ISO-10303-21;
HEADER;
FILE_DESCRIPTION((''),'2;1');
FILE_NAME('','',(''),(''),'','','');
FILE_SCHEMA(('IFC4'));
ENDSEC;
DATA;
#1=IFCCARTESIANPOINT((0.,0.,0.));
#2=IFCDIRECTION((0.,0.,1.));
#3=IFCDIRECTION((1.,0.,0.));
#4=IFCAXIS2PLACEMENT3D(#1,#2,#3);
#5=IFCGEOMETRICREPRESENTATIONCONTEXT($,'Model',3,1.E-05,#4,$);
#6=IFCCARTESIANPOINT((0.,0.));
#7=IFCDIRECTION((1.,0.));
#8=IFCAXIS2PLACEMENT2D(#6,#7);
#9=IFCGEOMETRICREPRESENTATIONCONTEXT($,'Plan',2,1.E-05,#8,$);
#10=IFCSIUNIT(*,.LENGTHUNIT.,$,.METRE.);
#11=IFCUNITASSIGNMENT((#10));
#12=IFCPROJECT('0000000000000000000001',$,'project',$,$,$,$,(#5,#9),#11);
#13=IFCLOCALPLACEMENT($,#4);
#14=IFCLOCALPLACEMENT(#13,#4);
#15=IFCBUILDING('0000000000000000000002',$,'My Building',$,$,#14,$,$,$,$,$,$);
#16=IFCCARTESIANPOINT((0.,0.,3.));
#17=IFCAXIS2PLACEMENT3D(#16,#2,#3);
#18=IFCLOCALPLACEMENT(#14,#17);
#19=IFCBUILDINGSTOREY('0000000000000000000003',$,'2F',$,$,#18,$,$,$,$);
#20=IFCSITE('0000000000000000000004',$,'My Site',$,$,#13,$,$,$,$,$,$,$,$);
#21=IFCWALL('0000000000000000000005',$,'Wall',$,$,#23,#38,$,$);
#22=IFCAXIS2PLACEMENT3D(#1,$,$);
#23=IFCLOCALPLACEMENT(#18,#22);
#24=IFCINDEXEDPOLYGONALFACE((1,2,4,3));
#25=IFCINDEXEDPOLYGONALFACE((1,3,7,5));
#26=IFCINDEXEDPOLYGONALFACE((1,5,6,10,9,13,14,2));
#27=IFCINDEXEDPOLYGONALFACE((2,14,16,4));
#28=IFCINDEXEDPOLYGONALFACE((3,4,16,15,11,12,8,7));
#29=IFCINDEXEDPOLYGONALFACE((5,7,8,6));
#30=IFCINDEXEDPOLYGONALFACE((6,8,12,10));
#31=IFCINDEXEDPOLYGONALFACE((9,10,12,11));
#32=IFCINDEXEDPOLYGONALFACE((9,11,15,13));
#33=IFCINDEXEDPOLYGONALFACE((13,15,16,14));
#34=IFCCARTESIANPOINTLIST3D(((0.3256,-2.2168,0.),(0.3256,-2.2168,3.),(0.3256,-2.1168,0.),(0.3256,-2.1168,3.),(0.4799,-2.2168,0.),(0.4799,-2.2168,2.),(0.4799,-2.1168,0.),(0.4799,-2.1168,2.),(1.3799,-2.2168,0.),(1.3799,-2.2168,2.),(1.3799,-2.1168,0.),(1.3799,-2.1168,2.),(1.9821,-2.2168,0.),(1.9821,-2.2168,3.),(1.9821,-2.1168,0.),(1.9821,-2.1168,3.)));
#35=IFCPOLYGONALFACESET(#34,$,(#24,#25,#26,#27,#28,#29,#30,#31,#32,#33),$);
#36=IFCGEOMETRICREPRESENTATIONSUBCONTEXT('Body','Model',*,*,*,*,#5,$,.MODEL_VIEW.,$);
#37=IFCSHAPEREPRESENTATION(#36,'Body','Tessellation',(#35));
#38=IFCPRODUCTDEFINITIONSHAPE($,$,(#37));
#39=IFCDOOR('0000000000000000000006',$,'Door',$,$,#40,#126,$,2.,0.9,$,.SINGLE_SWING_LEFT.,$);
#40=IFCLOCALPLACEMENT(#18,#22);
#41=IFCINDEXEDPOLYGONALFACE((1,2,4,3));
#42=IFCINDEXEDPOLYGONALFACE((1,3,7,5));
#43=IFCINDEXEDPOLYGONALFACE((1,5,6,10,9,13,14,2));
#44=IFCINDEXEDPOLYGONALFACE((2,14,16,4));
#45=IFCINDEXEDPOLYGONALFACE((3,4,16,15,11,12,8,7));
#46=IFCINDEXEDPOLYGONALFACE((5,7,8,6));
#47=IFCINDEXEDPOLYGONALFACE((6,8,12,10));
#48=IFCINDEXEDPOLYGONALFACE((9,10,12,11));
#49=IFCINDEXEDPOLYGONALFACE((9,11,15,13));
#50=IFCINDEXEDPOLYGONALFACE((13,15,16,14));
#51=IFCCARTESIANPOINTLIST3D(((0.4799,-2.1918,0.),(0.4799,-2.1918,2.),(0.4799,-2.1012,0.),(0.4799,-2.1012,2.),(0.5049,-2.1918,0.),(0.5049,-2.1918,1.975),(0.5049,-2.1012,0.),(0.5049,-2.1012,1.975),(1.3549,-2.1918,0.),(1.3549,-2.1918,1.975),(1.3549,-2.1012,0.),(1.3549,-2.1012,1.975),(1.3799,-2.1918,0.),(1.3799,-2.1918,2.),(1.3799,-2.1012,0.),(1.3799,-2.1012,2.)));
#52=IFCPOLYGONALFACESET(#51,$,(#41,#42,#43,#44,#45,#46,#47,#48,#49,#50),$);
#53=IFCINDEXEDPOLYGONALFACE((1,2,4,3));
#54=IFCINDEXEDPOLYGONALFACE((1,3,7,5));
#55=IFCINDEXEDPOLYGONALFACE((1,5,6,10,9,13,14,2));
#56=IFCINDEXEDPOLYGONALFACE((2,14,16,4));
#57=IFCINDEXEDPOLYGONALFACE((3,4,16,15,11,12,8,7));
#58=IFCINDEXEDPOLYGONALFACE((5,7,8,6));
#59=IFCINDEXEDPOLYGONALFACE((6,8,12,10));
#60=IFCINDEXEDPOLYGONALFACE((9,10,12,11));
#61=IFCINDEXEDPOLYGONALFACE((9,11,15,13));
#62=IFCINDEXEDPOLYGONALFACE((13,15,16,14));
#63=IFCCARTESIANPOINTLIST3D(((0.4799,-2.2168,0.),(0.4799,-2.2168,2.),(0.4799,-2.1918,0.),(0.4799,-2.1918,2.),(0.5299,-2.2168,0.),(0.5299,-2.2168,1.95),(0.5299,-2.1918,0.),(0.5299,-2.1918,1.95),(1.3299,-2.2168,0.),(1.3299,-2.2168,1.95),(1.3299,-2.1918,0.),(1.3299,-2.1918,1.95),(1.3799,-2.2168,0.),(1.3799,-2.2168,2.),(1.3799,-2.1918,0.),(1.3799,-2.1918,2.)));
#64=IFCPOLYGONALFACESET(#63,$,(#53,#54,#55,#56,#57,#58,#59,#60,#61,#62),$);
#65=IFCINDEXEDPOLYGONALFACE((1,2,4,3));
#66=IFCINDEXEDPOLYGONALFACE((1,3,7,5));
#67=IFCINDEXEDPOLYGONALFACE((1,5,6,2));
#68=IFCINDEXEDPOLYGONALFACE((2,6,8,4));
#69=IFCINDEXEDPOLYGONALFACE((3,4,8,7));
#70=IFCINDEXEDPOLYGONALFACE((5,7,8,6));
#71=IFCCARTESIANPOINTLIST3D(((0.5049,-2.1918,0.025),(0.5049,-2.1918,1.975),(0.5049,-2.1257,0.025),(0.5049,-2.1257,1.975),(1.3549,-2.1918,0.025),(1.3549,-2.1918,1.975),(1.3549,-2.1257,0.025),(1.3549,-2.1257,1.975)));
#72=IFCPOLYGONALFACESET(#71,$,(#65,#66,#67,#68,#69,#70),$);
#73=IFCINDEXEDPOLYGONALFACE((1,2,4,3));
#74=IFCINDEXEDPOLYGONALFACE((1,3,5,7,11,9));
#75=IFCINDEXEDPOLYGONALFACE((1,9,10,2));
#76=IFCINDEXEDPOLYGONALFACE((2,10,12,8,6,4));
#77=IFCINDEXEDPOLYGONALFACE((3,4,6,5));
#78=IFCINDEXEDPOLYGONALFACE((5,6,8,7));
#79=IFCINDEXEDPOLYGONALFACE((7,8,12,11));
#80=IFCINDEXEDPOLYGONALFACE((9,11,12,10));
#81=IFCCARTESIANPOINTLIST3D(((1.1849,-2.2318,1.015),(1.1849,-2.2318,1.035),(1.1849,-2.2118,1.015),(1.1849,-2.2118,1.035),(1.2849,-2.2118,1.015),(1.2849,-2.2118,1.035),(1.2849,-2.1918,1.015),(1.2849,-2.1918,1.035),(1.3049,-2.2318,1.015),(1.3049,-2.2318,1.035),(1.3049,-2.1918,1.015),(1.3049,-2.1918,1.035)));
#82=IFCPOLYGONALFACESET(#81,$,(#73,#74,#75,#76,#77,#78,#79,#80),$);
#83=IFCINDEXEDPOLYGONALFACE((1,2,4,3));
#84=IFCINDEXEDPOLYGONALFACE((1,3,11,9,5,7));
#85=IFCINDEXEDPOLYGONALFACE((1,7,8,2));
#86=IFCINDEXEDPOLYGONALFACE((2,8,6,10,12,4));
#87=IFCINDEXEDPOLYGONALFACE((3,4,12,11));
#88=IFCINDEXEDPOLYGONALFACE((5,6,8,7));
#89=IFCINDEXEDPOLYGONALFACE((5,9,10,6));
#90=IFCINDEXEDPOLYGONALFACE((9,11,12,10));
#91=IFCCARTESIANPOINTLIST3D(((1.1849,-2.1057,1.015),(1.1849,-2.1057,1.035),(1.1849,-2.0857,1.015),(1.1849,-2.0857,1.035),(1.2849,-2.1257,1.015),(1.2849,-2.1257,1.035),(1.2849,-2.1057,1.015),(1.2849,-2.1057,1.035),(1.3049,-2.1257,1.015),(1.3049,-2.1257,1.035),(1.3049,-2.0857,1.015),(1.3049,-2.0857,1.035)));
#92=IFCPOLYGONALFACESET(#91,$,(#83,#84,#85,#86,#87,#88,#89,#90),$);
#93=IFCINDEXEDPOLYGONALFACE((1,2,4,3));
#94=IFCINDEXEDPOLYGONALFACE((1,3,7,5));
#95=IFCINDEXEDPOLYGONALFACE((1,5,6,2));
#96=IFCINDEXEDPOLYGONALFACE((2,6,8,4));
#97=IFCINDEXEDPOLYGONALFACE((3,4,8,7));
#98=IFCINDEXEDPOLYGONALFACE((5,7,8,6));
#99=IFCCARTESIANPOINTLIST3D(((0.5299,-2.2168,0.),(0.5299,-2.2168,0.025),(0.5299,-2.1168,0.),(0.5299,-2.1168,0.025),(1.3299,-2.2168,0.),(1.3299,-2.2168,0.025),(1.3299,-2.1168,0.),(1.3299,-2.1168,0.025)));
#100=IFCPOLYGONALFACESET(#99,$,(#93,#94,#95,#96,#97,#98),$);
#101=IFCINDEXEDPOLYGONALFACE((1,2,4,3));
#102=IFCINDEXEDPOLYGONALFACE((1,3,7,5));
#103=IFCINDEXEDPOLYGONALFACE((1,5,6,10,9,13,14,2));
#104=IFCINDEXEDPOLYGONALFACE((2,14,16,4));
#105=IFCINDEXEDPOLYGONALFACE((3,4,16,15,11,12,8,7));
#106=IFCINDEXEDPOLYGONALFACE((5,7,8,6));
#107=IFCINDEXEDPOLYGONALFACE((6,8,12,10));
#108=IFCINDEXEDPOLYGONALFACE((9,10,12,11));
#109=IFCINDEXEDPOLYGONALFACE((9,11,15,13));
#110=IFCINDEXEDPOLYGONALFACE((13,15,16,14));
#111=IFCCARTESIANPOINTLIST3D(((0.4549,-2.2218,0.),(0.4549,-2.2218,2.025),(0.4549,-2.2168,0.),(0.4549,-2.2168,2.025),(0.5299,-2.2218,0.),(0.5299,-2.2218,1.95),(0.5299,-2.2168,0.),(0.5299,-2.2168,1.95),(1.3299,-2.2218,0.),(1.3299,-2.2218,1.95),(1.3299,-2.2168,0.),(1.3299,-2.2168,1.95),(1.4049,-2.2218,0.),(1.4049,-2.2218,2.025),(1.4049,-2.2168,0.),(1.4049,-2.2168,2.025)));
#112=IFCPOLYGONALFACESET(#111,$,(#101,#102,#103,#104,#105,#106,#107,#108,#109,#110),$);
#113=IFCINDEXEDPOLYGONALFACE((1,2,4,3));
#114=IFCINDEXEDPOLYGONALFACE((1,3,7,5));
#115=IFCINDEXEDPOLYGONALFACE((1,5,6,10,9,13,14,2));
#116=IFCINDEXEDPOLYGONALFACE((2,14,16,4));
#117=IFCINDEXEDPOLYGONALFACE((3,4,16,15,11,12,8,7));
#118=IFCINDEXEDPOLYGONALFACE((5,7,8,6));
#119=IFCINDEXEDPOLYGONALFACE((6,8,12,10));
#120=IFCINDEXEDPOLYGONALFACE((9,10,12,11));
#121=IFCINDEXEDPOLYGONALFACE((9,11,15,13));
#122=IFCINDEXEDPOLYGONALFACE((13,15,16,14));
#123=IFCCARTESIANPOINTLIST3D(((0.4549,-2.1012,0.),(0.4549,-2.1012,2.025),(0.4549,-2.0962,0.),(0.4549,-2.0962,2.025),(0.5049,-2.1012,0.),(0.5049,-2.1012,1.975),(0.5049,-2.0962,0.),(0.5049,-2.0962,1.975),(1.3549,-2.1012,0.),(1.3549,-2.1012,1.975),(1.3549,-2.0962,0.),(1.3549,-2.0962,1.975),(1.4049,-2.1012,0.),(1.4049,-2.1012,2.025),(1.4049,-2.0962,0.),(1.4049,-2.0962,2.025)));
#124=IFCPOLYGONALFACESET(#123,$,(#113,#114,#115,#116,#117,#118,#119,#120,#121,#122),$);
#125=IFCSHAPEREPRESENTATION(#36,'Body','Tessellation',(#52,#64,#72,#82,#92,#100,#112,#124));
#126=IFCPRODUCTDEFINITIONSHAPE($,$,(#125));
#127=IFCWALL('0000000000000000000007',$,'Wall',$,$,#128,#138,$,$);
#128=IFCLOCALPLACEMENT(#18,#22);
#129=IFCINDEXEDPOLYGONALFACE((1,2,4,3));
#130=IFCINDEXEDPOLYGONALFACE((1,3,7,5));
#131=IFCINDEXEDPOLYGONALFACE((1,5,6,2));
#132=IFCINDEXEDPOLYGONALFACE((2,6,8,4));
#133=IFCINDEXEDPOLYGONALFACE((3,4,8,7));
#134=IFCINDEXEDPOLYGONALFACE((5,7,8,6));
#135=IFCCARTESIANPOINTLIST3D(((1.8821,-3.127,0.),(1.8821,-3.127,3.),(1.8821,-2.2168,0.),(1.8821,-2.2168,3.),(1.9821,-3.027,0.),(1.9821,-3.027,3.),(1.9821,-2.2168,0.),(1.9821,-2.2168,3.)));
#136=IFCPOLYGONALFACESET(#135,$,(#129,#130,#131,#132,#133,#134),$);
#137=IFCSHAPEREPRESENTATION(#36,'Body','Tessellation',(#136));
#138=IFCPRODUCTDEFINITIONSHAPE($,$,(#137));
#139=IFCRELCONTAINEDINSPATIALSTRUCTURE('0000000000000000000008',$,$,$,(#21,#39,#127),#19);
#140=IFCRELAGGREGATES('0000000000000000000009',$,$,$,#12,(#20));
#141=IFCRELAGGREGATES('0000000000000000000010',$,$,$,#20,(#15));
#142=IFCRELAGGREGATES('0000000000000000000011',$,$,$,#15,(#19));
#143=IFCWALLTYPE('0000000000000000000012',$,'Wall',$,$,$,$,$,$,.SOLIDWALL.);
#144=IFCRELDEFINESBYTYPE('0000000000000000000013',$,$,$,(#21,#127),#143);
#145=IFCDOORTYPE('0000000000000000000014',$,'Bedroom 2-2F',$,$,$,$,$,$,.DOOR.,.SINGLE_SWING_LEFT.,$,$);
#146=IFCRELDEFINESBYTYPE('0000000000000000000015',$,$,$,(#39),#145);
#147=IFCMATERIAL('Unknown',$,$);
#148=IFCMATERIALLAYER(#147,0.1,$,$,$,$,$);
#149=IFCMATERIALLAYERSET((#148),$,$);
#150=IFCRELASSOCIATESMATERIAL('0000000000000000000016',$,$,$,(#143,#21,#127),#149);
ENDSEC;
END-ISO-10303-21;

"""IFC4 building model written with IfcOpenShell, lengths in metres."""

from ifc_helpers import new_model, entity, si_unit, frame, origin_with_axes, origin_2d_with_axis, place, context, subcontext, project, spatial, line, indexed_curve, outline, extrude, shape, source, transform, mapped, material, layer, layer_set, layer_usage, type_object, type_shapes, element, fill, save


model = new_model("IFC4")

# Units and contexts
model_context = context("Model", 3, precision=1e-05, world=origin_with_axes())
plan_context = context("Plan", 2, precision=1e-05, world=origin_2d_with_axis())
body_context_1 = subcontext(model_context, "Body", "Model", "MODEL_VIEW")
body_context_2 = subcontext(plan_context, "Body", "Plan", "PLAN_VIEW")
ifc_project = project(units=[si_unit("LENGTHUNIT", "METRE")], contexts=[model_context, plan_context])

# Site, building, storey
site_placement = place(None, origin_with_axes())
site = spatial("IfcSite", under=ifc_project, at=site_placement, Name="My Site")
building_placement = place(site_placement, origin_with_axes())
building = spatial("IfcBuilding", under=site, at=building_placement, Name="My Building")
storey_placement = place(building_placement, frame((0.0, 0.0, 3.0), z_axis=(0.0, 0.0, 1.0), x_axis=(1.0, 0.0, 0.0)))
storey = spatial("IfcBuildingStorey", under=building, at=storey_placement, Name="2F")

# Shared definitions
ifc_material = material(Name="Unknown")
ifc_layer = layer(ifc_material, 0.1)
ifc_layer_set = layer_set([ifc_layer])
wall_type = type_object("IfcWallType", Name="Wall", PredefinedType="SOLIDWALL", material=ifc_layer_set)

# Wall, opening, door
ifc_layer_usage_1 = layer_usage(ifc_layer_set, "AXIS2", "POSITIVE", 0.0)
wall_1_placement = place(storey_placement, frame((0.3256, -2.2168, 0.0), z_axis=(0.0, 0.0, 1.0), x_axis=(1.0, 0.0, 0.0)))
wall_1 = element("IfcWall", 1, at=wall_1_placement, inside=storey, type_object=wall_type, material=ifc_layer_usage_1, Name="Wall", context=body_context_1, shape_type="SweptSolid", body=[
    extrude(outline(indexed_curve([(0.0, 0.0), (0.0, 0.1), (1.6565, 0.1), (1.6565, 0.0)], segments=[line(1, 2, 3, 4, 1)])), origin_with_axes(), (0.0, 0.0, 1.0), 3.0),
])
shared_shape_1 = source(origin_with_axes(), body_context_1, "Body", "SweptSolid", [
    extrude(outline(indexed_curve([(0.0, 0.0), (0.9, 0.0), (0.9, 2.0), (0.0, 2.0)], segments=[line(1, 2, 3, 4, 1)])), frame((0.0, -0.6, 0.0), z_axis=(0.0, -1.0, 0.0), x_axis=(1.0, 0.0, 0.0)), (0.0, 0.0, -1.0), 1.2),
])
opening_1_placement = place(wall_1_placement, frame((0.1543, 0.0, 0.0), z_axis=(0.0, 0.0, 1.0), x_axis=(1.0, 0.0, 0.0)))
opening_1 = element("IfcOpeningElement", 2, at=opening_1_placement, cuts=wall_1, PredefinedType="OPENING", context=body_context_1, shape_type="MappedRepresentation", body=[
    mapped(shared_shape_1, transform((0.0, 0.0, 0.0), x_axis=(1.0, 0.0, 0.0), y_axis=(0.0, 1.0, 0.0), z_axis=(0.0, 0.0, 1.0), scale=1.0)),
])
door_type_1 = type_object("IfcDoorType", Name="Bedroom 2-2F", OperationType="SINGLE_SWING_LEFT", PredefinedType="DOOR")
shared_shape_2 = source(origin_with_axes(), body_context_1, "Body", "SweptSolid", [
    extrude(outline(indexed_curve([(0.0, 0.0), (0.0, 2.0), (0.9, 2.0), (0.9, 0.0), (0.875, 0.0), (0.875, 1.975), (0.025, 1.975), (0.025, 0.0)], segments=[line(1, 2, 3, 4, 5, 6, 7, 8, 1)])), frame((0.0, 0.025, 0.0), z_axis=(0.0, -1.0, 0.0), x_axis=(1.0, 0.0, 0.0)), (0.0, 0.0, -1.0), 0.0906),
    extrude(outline(indexed_curve([(0.0, 0.0), (0.0, 2.0), (0.9, 2.0), (0.9, 0.0), (0.85, 0.0), (0.85, 1.95), (0.05, 1.95), (0.05, 0.0)], segments=[line(1, 2, 3, 4, 5, 6, 7, 8, 1)])), frame((0.0, 0.0, 0.0), z_axis=(0.0, -1.0, 0.0), x_axis=(1.0, 0.0, 0.0)), (0.0, 0.0, -1.0), 0.025),
    extrude(outline(indexed_curve([(0.0, 0.0), (0.85, 0.0), (0.85, 0.0661), (0.0, 0.0661)], segments=[line(1, 2, 3, 4, 1)])), frame((0.025, 0.025, 0.025), z_axis=(0.0, 0.0, 1.0), x_axis=(1.0, 0.0, 0.0)), (0.0, 0.0, 1.0), 1.95),
    extrude(outline(indexed_curve([(0.0, 0.0), (0.0, -0.04), (-0.12, -0.04), (-0.12, -0.02), (-0.02, -0.02), (-0.02, 0.0)], segments=[line(1, 2, 3, 4, 5, 6, 1)])), frame((0.825, 0.025, 1.015), z_axis=(0.0, 0.0, 1.0), x_axis=(1.0, 0.0, 0.0)), (0.0, 0.0, 1.0), 0.02),
    extrude(outline(indexed_curve([(0.0, 0.0), (0.0, 0.04), (-0.12, 0.04), (-0.12, 0.02), (-0.02, 0.02), (-0.02, 0.0)], segments=[line(1, 2, 3, 4, 5, 6, 1)])), frame((0.825, 0.0911, 1.015), z_axis=(0.0, 0.0, 1.0), x_axis=(1.0, 0.0, 0.0)), (0.0, 0.0, 1.0), 0.02),
    extrude(outline(indexed_curve([(0.0, 0.0), (0.8, 0.0), (0.8, 0.1), (0.0, 0.1)], segments=[line(1, 2, 3, 4, 1)])), frame((0.05, 0.0, 0.0), z_axis=(0.0, 0.0, 1.0), x_axis=(1.0, 0.0, 0.0)), (0.0, 0.0, 1.0), 0.025),
    extrude(outline(indexed_curve([(0.0, 0.0), (0.0, 2.025), (0.95, 2.025), (0.95, 0.0), (0.875, 0.0), (0.875, 1.95), (0.075, 1.95), (0.075, 0.0)], segments=[line(1, 2, 3, 4, 5, 6, 7, 8, 1)])), frame((-0.025, -0.005, 0.0), z_axis=(0.0, -1.0, 0.0), x_axis=(1.0, 0.0, 0.0)), (0.0, 0.0, -1.0), 0.005),
    extrude(outline(indexed_curve([(0.0, 0.0), (0.0, 2.025), (0.95, 2.025), (0.95, 0.0), (0.9, 0.0), (0.9, 1.975), (0.05, 1.975), (0.05, 0.0)], segments=[line(1, 2, 3, 4, 5, 6, 7, 8, 1)])), frame((-0.025, 0.1156, 0.0), z_axis=(0.0, -1.0, 0.0), x_axis=(1.0, 0.0, 0.0)), (0.0, 0.0, -1.0), 0.005),
])
shared_shape_3 = source(origin_with_axes(), body_context_2, "Body", "Curve2D", [
    entity("IfcIndexedPolyCurve", entity("IfcCartesianPointList2D", [[0.0, 0.0], [0.0, 0.1156], [0.025, 0.1156], [0.025, 0.025], [0.05, 0.025], [0.05, 0.0]]), [entity("IfcLineIndex", [1, 2, 3, 4, 5, 6, 1])]),
    entity("IfcIndexedPolyCurve", entity("IfcCartesianPointList2D", [[0.9, 0.0], [0.9, 0.1156], [0.875, 0.1156], [0.875, 0.025], [0.85, 0.025], [0.85, 0.0]]), [entity("IfcLineIndex", [1, 2, 3, 4, 5, 6, 1])]),
    entity("IfcTrimmedCurve", entity("IfcEllipse", entity("IfcAxis2Placement2D", entity("IfcCartesianPoint", [0.0911, 0.1156]), entity("IfcDirection", [1.0, 0.0])), 0.7839, 0.85), [entity("IfcCartesianPoint", [0.875, 0.1156])], [entity("IfcCartesianPoint", [0.0911, 0.9656])], True, "CARTESIAN"),
    entity("IfcIndexedPolyCurve", entity("IfcCartesianPointList2D", [[0.025, 0.1156], [0.0911, 0.1156], [0.0911, 0.9656], [0.025, 0.9656]]), [entity("IfcLineIndex", [1, 2, 3, 4, 1])]),
])
type_shapes(door_type_1, [shared_shape_2, shared_shape_3])
door_1_placement = place(opening_1_placement, frame((0.0, 0.0, 0.0), z_axis=(0.0, 0.0, 1.0), x_axis=(1.0, 0.0, 0.0)))
door_1 = element("IfcDoor", 3, at=door_1_placement, inside=storey, type_object=door_type_1, Name="Door", OperationType="SINGLE_SWING_LEFT", OverallHeight=2.0, OverallWidth=0.9, shapes=[
    shape(body_context_1, "Body", "MappedRepresentation", [mapped(shared_shape_2, transform((0.0, 0.0, 0.0), x_axis=(1.0, 0.0, 0.0), y_axis=(0.0, 1.0, 0.0), z_axis=(0.0, 0.0, 1.0), scale=1.0))]),
    shape(body_context_2, "Body", "MappedRepresentation", [mapped(shared_shape_3, transform((0.0, 0.0, 0.0), x_axis=(1.0, 0.0, 0.0), y_axis=(0.0, 1.0, 0.0), z_axis=(0.0, 0.0, 1.0), scale=1.0))]),
])
fill(opening_1, door_1)

# Wall
ifc_layer_usage_2 = layer_usage(ifc_layer_set, "AXIS2", "POSITIVE", 0.0)
wall_2_placement = place(storey_placement, frame((1.8821, -2.2168, 0.0), z_axis=(0.0, 0.0, 1.0), x_axis=(0.0, -1.0, 0.0)))
element("IfcWall", 4, at=wall_2_placement, inside=storey, type_object=wall_type, material=ifc_layer_usage_2, Name="Wall", context=body_context_1, shape_type="SweptSolid", body=[
    extrude(outline(indexed_curve([(0.0, 0.0), (0.0, 0.1), (0.8102, 0.1), (0.9102, 0.0)], segments=[line(1, 2, 3, 4, 1)])), origin_with_axes(), (0.0, 0.0, 1.0), 3.0),
])

save(model, "model.ifc")
